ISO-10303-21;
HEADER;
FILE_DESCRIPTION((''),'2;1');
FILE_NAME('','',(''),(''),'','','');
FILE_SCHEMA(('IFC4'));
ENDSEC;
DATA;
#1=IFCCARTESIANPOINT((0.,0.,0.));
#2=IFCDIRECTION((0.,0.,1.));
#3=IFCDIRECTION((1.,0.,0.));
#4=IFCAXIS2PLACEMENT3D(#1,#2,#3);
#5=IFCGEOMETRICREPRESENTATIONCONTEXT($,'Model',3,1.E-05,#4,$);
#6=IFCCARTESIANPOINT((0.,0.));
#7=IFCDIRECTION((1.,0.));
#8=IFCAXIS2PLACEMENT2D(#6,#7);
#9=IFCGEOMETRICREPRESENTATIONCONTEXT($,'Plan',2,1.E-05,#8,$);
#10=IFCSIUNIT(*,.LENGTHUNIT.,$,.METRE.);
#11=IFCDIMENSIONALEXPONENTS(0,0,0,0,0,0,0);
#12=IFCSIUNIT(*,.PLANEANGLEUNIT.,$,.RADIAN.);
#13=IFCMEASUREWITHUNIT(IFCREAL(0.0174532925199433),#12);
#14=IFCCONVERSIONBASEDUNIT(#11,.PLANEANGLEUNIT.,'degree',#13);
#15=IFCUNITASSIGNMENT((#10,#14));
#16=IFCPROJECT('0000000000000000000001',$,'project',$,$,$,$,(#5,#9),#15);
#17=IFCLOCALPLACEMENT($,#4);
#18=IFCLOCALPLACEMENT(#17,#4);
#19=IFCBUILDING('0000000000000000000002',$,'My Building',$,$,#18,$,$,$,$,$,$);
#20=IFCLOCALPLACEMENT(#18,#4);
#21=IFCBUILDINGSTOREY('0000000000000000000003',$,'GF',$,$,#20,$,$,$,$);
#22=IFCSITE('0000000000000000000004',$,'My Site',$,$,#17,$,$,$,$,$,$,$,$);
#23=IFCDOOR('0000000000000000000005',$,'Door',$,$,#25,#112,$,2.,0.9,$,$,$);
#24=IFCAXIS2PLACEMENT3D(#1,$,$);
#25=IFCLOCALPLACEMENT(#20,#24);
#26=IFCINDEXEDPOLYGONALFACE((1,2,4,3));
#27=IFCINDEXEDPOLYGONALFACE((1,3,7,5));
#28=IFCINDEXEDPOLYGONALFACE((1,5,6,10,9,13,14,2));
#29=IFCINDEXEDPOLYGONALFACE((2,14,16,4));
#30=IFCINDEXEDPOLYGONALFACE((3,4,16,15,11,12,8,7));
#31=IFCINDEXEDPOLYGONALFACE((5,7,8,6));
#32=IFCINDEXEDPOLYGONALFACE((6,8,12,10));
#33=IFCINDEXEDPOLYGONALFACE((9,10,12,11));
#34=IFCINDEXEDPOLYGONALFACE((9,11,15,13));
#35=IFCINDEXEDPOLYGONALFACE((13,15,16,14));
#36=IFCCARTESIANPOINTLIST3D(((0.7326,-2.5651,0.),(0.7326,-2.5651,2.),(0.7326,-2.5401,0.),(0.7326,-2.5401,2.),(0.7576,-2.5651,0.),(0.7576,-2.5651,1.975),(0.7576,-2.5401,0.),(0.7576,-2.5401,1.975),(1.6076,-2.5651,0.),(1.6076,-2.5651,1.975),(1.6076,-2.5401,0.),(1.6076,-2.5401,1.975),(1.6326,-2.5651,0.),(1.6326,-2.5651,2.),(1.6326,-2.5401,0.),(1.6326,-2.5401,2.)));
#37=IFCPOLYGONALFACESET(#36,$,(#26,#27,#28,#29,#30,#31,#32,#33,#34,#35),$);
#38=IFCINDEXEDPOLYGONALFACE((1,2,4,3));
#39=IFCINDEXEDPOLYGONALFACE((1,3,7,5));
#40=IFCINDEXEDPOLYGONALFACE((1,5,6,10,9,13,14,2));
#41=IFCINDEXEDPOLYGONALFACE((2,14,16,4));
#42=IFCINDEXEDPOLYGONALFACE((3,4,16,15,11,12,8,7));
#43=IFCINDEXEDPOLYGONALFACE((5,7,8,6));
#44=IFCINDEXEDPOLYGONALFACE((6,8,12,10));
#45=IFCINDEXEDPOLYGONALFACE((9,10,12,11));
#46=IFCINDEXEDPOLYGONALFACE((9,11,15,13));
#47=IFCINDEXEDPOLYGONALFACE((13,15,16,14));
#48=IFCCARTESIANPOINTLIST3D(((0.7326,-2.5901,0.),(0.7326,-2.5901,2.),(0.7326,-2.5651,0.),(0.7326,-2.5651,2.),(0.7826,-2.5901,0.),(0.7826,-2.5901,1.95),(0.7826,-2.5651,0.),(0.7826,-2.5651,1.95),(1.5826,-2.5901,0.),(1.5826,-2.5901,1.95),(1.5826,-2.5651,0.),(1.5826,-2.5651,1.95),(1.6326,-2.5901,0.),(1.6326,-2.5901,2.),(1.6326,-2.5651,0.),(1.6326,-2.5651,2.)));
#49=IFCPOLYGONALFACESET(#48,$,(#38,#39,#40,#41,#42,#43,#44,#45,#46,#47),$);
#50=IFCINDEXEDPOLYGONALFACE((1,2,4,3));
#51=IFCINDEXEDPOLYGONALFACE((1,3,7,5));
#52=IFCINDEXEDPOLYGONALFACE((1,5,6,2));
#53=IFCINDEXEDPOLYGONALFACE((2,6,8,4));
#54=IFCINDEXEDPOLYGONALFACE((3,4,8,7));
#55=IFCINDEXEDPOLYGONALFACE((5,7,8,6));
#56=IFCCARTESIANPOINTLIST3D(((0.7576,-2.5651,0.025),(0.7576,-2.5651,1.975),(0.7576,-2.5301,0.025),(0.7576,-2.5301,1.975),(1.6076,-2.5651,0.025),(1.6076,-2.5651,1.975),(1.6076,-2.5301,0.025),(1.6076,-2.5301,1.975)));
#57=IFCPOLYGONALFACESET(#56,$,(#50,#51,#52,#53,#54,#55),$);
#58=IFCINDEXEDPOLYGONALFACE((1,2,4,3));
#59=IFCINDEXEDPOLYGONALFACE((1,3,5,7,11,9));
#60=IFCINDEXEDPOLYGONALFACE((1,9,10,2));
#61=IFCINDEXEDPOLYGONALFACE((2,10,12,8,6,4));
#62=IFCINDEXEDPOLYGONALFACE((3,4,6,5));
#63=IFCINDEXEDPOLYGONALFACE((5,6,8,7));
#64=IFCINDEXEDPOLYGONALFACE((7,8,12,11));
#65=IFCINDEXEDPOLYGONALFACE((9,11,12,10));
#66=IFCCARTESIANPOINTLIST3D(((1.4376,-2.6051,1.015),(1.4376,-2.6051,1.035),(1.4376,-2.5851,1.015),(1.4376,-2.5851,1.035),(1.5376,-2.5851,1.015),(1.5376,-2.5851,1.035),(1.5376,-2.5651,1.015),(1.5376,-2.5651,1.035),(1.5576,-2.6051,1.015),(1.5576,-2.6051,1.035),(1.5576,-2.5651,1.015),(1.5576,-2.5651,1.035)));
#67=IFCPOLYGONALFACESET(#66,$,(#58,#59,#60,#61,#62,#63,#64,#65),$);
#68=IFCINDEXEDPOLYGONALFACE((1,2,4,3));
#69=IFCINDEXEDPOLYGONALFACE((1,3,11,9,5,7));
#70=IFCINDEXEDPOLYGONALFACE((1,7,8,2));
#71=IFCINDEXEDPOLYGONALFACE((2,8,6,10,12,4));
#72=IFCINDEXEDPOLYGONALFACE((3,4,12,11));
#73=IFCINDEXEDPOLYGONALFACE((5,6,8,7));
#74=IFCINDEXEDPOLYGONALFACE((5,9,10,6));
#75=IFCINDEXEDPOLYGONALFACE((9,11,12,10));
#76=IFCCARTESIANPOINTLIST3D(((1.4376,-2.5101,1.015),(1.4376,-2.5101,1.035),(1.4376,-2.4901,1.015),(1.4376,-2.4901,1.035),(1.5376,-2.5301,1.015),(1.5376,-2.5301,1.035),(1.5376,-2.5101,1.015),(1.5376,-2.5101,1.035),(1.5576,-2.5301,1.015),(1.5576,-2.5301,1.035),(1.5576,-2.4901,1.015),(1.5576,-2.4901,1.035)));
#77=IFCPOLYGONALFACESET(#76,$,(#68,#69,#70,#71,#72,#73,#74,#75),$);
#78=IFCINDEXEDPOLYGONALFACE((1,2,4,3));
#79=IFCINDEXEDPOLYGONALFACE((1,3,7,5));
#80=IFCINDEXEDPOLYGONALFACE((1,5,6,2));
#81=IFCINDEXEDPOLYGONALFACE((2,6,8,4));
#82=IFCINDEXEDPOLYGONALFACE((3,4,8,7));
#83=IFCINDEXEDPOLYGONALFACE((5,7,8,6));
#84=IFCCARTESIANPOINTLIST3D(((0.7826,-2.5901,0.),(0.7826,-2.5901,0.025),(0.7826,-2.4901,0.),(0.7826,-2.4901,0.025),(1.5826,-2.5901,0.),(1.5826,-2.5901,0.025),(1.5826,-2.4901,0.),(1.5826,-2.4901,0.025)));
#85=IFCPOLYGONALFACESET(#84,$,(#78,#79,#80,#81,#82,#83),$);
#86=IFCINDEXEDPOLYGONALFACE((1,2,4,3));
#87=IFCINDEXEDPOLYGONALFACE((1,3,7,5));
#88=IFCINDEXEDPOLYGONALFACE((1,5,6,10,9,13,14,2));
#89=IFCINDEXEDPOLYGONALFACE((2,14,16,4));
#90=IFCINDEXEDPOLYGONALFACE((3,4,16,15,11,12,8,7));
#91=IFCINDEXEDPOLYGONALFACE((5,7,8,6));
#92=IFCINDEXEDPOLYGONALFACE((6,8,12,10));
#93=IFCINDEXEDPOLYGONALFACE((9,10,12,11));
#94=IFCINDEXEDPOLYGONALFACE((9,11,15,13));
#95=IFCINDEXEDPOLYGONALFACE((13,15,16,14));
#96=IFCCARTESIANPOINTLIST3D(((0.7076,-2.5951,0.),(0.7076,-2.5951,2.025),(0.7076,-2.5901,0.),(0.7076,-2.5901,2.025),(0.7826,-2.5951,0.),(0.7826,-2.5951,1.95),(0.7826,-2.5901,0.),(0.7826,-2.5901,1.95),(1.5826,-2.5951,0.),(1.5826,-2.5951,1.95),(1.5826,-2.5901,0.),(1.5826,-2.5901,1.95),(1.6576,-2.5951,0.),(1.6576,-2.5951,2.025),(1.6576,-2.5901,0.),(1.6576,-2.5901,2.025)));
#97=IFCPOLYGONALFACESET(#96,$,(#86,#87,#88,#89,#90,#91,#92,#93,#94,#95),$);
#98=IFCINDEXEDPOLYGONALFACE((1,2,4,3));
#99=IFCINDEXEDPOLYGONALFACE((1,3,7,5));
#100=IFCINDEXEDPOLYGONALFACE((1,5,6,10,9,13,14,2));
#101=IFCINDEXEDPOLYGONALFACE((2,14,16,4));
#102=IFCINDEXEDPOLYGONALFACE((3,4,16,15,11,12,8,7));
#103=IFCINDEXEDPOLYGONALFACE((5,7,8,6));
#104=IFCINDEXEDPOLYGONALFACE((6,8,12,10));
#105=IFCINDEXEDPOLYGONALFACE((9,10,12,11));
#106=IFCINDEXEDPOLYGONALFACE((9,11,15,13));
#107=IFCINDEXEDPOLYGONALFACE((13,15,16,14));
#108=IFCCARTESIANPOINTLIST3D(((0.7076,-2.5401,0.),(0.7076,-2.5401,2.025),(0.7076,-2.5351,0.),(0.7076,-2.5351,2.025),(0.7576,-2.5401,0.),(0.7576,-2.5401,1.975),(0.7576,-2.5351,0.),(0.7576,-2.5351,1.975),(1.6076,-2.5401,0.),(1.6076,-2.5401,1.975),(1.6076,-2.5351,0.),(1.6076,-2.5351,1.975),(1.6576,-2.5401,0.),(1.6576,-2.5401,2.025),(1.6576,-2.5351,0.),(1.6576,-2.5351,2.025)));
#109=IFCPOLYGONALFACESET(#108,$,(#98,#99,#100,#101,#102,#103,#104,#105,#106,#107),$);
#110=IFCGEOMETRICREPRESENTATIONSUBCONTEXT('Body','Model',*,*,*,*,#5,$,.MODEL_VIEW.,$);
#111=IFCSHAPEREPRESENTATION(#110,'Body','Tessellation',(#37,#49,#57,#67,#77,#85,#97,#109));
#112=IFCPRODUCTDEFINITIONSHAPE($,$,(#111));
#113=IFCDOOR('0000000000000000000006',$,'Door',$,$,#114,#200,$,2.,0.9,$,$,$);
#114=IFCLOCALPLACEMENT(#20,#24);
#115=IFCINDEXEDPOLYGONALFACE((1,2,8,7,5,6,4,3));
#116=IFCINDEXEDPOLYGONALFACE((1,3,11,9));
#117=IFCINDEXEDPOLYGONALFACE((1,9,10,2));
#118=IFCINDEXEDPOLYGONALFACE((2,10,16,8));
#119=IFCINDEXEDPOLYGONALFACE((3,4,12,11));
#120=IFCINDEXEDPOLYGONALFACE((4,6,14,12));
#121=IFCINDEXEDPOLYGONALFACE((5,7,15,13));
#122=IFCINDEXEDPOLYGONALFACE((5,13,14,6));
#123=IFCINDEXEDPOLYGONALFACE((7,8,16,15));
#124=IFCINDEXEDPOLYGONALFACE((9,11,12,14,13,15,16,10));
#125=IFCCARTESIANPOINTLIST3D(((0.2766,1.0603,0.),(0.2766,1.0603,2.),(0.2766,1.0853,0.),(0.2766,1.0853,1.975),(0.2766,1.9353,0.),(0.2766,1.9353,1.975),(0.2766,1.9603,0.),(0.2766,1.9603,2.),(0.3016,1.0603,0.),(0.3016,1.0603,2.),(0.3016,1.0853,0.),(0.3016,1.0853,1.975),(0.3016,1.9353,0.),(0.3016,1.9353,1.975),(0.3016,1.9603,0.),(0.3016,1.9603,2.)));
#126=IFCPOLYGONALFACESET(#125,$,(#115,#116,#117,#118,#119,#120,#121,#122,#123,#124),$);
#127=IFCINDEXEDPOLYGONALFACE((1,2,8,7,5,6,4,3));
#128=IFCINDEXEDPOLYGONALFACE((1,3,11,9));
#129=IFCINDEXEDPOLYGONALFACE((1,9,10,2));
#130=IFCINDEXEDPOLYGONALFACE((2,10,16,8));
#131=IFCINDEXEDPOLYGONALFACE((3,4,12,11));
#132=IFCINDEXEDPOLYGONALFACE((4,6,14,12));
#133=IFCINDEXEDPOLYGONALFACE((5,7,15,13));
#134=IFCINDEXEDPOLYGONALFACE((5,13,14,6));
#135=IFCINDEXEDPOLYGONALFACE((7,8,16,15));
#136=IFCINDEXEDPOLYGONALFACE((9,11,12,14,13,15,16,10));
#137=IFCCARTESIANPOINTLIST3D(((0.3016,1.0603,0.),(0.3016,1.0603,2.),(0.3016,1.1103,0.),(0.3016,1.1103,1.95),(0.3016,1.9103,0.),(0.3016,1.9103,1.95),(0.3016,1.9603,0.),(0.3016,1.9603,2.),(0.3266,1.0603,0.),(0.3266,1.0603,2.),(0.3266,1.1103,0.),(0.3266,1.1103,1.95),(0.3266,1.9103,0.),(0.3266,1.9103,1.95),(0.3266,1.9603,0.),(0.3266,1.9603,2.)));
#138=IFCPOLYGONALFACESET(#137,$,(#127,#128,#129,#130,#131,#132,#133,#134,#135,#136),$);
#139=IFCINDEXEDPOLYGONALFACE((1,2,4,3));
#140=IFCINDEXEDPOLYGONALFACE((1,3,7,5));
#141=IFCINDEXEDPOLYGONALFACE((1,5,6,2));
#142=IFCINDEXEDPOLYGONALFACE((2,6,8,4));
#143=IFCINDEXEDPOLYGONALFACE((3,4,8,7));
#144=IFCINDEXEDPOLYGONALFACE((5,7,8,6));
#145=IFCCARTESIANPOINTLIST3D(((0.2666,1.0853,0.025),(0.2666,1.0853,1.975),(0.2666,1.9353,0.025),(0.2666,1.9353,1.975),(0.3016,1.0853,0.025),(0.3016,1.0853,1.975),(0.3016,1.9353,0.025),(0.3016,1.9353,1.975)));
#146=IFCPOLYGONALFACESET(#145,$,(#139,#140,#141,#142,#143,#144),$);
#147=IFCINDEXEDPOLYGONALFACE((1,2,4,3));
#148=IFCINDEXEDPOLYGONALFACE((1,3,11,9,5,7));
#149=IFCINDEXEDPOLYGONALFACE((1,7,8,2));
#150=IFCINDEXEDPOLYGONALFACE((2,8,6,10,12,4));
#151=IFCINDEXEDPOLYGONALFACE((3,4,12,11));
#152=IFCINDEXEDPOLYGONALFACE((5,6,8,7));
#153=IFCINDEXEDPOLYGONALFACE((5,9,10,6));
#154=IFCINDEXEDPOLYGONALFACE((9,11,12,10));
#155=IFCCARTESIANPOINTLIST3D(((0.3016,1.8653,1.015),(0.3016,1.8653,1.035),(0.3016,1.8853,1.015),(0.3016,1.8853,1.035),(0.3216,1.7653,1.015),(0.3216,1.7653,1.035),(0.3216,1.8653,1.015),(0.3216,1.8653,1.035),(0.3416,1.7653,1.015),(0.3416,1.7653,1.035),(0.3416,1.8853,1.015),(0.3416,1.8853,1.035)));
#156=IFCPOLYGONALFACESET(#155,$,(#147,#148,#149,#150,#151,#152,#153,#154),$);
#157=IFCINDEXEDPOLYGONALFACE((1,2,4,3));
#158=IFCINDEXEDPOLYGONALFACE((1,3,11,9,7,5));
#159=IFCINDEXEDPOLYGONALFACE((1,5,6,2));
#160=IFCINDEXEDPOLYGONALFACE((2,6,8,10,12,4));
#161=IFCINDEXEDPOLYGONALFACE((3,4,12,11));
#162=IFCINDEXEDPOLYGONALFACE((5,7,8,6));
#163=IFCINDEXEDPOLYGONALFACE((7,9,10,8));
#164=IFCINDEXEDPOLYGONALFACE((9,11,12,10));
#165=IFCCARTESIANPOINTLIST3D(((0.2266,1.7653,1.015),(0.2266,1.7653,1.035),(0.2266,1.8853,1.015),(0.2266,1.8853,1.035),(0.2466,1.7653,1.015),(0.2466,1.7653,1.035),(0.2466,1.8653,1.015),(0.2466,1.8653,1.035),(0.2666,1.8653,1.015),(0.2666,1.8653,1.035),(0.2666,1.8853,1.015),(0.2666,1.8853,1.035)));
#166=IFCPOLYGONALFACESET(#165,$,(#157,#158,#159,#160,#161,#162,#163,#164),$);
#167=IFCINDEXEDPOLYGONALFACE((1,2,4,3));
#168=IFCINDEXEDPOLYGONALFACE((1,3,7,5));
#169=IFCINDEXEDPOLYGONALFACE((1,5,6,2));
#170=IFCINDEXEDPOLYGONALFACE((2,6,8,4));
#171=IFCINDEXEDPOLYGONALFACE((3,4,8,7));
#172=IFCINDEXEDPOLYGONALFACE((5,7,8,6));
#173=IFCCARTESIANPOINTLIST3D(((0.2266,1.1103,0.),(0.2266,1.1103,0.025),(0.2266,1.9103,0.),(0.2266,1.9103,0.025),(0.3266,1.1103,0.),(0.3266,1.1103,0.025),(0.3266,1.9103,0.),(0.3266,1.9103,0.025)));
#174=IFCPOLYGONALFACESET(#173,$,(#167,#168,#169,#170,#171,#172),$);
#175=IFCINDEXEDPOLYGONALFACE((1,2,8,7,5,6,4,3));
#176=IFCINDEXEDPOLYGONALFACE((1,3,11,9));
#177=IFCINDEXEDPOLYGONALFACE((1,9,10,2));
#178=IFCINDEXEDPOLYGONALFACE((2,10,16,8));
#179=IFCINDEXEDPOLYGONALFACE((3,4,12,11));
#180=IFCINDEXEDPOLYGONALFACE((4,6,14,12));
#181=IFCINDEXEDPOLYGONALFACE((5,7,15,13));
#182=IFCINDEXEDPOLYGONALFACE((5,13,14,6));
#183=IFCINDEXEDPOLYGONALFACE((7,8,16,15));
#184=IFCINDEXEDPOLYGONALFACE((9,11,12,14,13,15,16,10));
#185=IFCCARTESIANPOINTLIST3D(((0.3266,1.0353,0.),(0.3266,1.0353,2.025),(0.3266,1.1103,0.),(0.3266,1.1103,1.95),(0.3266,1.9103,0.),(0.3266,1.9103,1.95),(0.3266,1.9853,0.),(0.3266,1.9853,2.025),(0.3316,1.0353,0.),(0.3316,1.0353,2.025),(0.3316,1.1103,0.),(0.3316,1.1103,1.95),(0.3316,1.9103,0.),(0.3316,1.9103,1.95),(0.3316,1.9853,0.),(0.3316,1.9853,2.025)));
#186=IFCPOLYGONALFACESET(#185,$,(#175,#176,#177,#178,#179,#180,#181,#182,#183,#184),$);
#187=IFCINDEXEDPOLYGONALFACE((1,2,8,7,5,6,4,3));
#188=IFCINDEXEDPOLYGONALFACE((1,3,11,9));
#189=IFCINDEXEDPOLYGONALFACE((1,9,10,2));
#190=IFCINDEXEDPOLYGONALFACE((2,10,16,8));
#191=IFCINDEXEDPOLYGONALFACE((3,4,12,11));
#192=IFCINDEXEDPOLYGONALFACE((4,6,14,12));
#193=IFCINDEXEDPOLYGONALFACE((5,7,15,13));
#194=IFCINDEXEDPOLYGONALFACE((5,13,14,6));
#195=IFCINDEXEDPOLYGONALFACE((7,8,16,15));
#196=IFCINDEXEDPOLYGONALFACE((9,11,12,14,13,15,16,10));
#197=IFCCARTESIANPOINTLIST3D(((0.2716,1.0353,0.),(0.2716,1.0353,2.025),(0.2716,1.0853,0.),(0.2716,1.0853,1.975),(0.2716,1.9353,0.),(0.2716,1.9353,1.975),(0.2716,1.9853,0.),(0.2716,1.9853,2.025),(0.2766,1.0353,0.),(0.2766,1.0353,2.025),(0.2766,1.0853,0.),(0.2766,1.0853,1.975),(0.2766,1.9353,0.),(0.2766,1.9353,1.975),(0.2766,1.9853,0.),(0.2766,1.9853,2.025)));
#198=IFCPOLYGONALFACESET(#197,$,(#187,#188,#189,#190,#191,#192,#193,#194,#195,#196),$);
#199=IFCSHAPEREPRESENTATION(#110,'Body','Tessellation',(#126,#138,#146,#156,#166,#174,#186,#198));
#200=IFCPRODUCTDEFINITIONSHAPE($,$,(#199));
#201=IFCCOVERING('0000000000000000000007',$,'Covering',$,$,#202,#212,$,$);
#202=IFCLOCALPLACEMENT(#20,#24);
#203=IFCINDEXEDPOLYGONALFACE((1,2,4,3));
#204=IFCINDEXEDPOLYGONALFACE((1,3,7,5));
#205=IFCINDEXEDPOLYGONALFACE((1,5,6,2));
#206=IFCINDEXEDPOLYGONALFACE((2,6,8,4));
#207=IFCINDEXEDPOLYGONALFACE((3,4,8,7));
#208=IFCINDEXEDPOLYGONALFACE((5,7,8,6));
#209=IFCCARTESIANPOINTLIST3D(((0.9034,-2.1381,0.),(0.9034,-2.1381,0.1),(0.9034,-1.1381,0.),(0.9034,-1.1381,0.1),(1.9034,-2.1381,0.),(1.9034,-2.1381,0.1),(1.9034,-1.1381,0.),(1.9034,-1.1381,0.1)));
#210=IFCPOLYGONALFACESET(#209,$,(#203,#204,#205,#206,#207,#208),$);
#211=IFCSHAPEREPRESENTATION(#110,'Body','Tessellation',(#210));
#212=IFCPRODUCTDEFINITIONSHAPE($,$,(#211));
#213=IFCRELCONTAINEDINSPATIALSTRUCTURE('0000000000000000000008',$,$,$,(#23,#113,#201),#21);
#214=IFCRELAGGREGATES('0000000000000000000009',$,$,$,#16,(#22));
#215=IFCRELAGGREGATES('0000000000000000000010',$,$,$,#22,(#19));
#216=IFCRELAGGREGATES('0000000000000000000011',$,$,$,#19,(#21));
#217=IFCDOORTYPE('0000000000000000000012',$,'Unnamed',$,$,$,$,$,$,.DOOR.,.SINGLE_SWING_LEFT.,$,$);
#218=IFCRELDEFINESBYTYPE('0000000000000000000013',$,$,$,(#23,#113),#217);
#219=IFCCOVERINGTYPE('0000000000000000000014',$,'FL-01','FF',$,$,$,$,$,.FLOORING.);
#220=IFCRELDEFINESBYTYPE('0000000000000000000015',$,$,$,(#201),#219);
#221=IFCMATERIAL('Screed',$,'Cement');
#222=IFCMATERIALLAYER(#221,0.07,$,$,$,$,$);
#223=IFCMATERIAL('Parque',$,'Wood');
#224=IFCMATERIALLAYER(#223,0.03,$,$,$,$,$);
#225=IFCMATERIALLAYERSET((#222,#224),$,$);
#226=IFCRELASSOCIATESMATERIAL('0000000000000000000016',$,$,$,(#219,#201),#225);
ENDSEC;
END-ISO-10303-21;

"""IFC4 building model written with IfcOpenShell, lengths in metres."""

from ifc_helpers import new_model, entity, si_unit, converted_unit, frame, origin_with_axes, origin_2d_with_axis, place, context, subcontext, project, spatial, line, indexed_curve, outline, extrude, shape, source, transform, mapped, material, layer, layer_set, layer_usage, type_object, type_shapes, element, save


model = new_model("IFC4")

# Units and contexts
model_context = context("Model", 3, precision=1e-05, world=origin_with_axes())
plan_context = context("Plan", 2, precision=1e-05, world=origin_2d_with_axis())
body_context_1 = subcontext(model_context, "Body", "Model", "MODEL_VIEW")
body_context_2 = subcontext(plan_context, "Body", "Plan", "PLAN_VIEW")
ifc_project = project(units=[si_unit("LENGTHUNIT", "METRE"), converted_unit("PLANEANGLEUNIT", "degree", entity("IfcReal", 0.0174532925199433), si_unit("PLANEANGLEUNIT", "RADIAN"), dimensions=[0, 0, 0, 0, 0, 0, 0])], contexts=[model_context, plan_context])

# Site, building, storey
site_placement = place(None, origin_with_axes())
site = spatial("IfcSite", under=ifc_project, at=site_placement, Name="My Site")
building_placement = place(site_placement, origin_with_axes())
building = spatial("IfcBuilding", under=site, at=building_placement, Name="My Building")
storey_placement = place(building_placement, origin_with_axes())
storey = spatial("IfcBuildingStorey", under=building, at=storey_placement, Name="GF")

# Doors
door_type = type_object("IfcDoorType", Name="Unnamed", OperationType="SINGLE_SWING_LEFT", PredefinedType="DOOR")
shared_shape_1 = source(origin_with_axes(), body_context_1, "Body", "SweptSolid", [
    extrude(outline(indexed_curve([(0.0, 0.0), (0.0, 2.0), (0.9, 2.0), (0.9, 0.0), (0.875, 0.0), (0.875, 1.975), (0.025, 1.975), (0.025, 0.0)], segments=[line(1, 2, 3, 4, 5, 6, 7, 8, 1)])), frame((0.0, 0.025, 0.0), z_axis=(0.0, -1.0, 0.0), x_axis=(1.0, 0.0, 0.0)), (0.0, 0.0, -1.0), 0.025),
    extrude(outline(indexed_curve([(0.0, 0.0), (0.0, 2.0), (0.9, 2.0), (0.9, 0.0), (0.85, 0.0), (0.85, 1.95), (0.05, 1.95), (0.05, 0.0)], segments=[line(1, 2, 3, 4, 5, 6, 7, 8, 1)])), frame((0.0, 0.0, 0.0), z_axis=(0.0, -1.0, 0.0), x_axis=(1.0, 0.0, 0.0)), (0.0, 0.0, -1.0), 0.025),
    extrude(outline(indexed_curve([(0.0, 0.0), (0.85, 0.0), (0.85, 0.035), (0.0, 0.035)], segments=[line(1, 2, 3, 4, 1)])), frame((0.025, 0.025, 0.025), z_axis=(0.0, 0.0, 1.0), x_axis=(1.0, 0.0, 0.0)), (0.0, 0.0, 1.0), 1.95),
    extrude(outline(indexed_curve([(0.0, 0.0), (0.0, -0.04), (-0.12, -0.04), (-0.12, -0.02), (-0.02, -0.02), (-0.02, 0.0)], segments=[line(1, 2, 3, 4, 5, 6, 1)])), frame((0.825, 0.025, 1.015), z_axis=(0.0, 0.0, 1.0), x_axis=(1.0, 0.0, 0.0)), (0.0, 0.0, 1.0), 0.02),
    extrude(outline(indexed_curve([(0.0, 0.0), (0.0, 0.04), (-0.12, 0.04), (-0.12, 0.02), (-0.02, 0.02), (-0.02, 0.0)], segments=[line(1, 2, 3, 4, 5, 6, 1)])), frame((0.825, 0.06, 1.015), z_axis=(0.0, 0.0, 1.0), x_axis=(1.0, 0.0, 0.0)), (0.0, 0.0, 1.0), 0.02),
    extrude(outline(indexed_curve([(0.0, 0.0), (0.8, 0.0), (0.8, 0.1), (0.0, 0.1)], segments=[line(1, 2, 3, 4, 1)])), frame((0.05, 0.0, 0.0), z_axis=(0.0, 0.0, 1.0), x_axis=(1.0, 0.0, 0.0)), (0.0, 0.0, 1.0), 0.025),
    extrude(outline(indexed_curve([(0.0, 0.0), (0.0, 2.025), (0.95, 2.025), (0.95, 0.0), (0.875, 0.0), (0.875, 1.95), (0.075, 1.95), (0.075, 0.0)], segments=[line(1, 2, 3, 4, 5, 6, 7, 8, 1)])), frame((-0.025, -0.005, 0.0), z_axis=(0.0, -1.0, 0.0), x_axis=(1.0, 0.0, 0.0)), (0.0, 0.0, -1.0), 0.005),
    extrude(outline(indexed_curve([(0.0, 0.0), (0.0, 2.025), (0.95, 2.025), (0.95, 0.0), (0.9, 0.0), (0.9, 1.975), (0.05, 1.975), (0.05, 0.0)], segments=[line(1, 2, 3, 4, 5, 6, 7, 8, 1)])), frame((-0.025, 0.05, 0.0), z_axis=(0.0, -1.0, 0.0), x_axis=(1.0, 0.0, 0.0)), (0.0, 0.0, -1.0), 0.005),
])
shared_shape_2 = source(origin_with_axes(), body_context_2, "Body", "Curve2D", [
    entity("IfcIndexedPolyCurve", entity("IfcCartesianPointList2D", [[0.0, 0.0], [0.0, 0.05], [0.025, 0.05], [0.025, 0.025], [0.05, 0.025], [0.05, 0.0]]), [entity("IfcLineIndex", [1, 2, 3, 4, 5, 6, 1])]),
    entity("IfcIndexedPolyCurve", entity("IfcCartesianPointList2D", [[0.9, 0.0], [0.9, 0.05], [0.875, 0.05], [0.875, 0.025], [0.85, 0.025], [0.85, 0.0]]), [entity("IfcLineIndex", [1, 2, 3, 4, 5, 6, 1])]),
    entity("IfcTrimmedCurve", entity("IfcEllipse", entity("IfcAxis2Placement2D", entity("IfcCartesianPoint", [0.06, 0.05]), entity("IfcDirection", [1.0, 0.0])), 0.815, 0.85), [entity("IfcCartesianPoint", [0.875, 0.05])], [entity("IfcCartesianPoint", [0.06, 0.9])], True, "CARTESIAN"),
    entity("IfcIndexedPolyCurve", entity("IfcCartesianPointList2D", [[0.025, 0.05], [0.06, 0.05], [0.06, 0.9], [0.025, 0.9]]), [entity("IfcLineIndex", [1, 2, 3, 4, 1])]),
])
type_shapes(door_type, [shared_shape_1, shared_shape_2])
for number, where, z_axis, x_axis, name in (
    (1, (0.7326, -2.5901, 0.0), (0.0, 0.0, 1.0), (1.0, 0.0, 0.0), "Door"),
    (2, (0.3266, 1.0603, 0.0), (0.0, 0.0, 1.0), (0.0, 1.0, 0.0), "Door"),
):
    element("IfcDoor", number, at=place(storey_placement, frame(where, z_axis=z_axis, x_axis=x_axis)), inside=storey, type_object=door_type, Name=name, OverallHeight=2.0, OverallWidth=0.9, shapes=[
        shape(body_context_1, "Body", "MappedRepresentation", [mapped(shared_shape_1, transform((0.0, 0.0, 0.0), x_axis=(1.0, 0.0, 0.0), y_axis=(0.0, 1.0, 0.0), z_axis=(0.0, 0.0, 1.0), scale=1.0))]),
        shape(body_context_2, "Body", "MappedRepresentation", [mapped(shared_shape_2, transform((0.0, 0.0, 0.0), x_axis=(1.0, 0.0, 0.0), y_axis=(0.0, 1.0, 0.0), z_axis=(0.0, 0.0, 1.0), scale=1.0))]),
    ])

# Covering
ifc_material_1 = material(Name="Screed", Category="Cement")
ifc_layer_1 = layer(ifc_material_1, 0.07)
ifc_material_2 = material(Name="Parque", Category="Wood")
ifc_layer_2 = layer(ifc_material_2, 0.03)
ifc_layer_set_1 = layer_set([ifc_layer_1, ifc_layer_2])
ifc_layer_usage_1 = layer_usage(ifc_layer_set_1, "AXIS3", "POSITIVE", 0.0)
covering_type = type_object("IfcCoveringType", Name="FL-01", Description="FF", PredefinedType="FLOORING", material=ifc_layer_set_1)
covering_placement = place(storey_placement, frame((0.9034, -2.1381, 0.0), z_axis=(0.0, 0.0, 1.0), x_axis=(1.0, 0.0, 0.0)))
element("IfcCovering", 3, at=covering_placement, inside=storey, type_object=covering_type, material=ifc_layer_usage_1, Name="Covering", context=body_context_1, shape_type="SweptSolid", body=[
    extrude(outline(indexed_curve([(0.0, 0.0), (1.0, 0.0), (1.0, 1.0), (0.0, 1.0), (0.0, 0.0)])), None, (0.0, 0.0, 1.0), 0.1),
])

save(model, "model.ifc")
